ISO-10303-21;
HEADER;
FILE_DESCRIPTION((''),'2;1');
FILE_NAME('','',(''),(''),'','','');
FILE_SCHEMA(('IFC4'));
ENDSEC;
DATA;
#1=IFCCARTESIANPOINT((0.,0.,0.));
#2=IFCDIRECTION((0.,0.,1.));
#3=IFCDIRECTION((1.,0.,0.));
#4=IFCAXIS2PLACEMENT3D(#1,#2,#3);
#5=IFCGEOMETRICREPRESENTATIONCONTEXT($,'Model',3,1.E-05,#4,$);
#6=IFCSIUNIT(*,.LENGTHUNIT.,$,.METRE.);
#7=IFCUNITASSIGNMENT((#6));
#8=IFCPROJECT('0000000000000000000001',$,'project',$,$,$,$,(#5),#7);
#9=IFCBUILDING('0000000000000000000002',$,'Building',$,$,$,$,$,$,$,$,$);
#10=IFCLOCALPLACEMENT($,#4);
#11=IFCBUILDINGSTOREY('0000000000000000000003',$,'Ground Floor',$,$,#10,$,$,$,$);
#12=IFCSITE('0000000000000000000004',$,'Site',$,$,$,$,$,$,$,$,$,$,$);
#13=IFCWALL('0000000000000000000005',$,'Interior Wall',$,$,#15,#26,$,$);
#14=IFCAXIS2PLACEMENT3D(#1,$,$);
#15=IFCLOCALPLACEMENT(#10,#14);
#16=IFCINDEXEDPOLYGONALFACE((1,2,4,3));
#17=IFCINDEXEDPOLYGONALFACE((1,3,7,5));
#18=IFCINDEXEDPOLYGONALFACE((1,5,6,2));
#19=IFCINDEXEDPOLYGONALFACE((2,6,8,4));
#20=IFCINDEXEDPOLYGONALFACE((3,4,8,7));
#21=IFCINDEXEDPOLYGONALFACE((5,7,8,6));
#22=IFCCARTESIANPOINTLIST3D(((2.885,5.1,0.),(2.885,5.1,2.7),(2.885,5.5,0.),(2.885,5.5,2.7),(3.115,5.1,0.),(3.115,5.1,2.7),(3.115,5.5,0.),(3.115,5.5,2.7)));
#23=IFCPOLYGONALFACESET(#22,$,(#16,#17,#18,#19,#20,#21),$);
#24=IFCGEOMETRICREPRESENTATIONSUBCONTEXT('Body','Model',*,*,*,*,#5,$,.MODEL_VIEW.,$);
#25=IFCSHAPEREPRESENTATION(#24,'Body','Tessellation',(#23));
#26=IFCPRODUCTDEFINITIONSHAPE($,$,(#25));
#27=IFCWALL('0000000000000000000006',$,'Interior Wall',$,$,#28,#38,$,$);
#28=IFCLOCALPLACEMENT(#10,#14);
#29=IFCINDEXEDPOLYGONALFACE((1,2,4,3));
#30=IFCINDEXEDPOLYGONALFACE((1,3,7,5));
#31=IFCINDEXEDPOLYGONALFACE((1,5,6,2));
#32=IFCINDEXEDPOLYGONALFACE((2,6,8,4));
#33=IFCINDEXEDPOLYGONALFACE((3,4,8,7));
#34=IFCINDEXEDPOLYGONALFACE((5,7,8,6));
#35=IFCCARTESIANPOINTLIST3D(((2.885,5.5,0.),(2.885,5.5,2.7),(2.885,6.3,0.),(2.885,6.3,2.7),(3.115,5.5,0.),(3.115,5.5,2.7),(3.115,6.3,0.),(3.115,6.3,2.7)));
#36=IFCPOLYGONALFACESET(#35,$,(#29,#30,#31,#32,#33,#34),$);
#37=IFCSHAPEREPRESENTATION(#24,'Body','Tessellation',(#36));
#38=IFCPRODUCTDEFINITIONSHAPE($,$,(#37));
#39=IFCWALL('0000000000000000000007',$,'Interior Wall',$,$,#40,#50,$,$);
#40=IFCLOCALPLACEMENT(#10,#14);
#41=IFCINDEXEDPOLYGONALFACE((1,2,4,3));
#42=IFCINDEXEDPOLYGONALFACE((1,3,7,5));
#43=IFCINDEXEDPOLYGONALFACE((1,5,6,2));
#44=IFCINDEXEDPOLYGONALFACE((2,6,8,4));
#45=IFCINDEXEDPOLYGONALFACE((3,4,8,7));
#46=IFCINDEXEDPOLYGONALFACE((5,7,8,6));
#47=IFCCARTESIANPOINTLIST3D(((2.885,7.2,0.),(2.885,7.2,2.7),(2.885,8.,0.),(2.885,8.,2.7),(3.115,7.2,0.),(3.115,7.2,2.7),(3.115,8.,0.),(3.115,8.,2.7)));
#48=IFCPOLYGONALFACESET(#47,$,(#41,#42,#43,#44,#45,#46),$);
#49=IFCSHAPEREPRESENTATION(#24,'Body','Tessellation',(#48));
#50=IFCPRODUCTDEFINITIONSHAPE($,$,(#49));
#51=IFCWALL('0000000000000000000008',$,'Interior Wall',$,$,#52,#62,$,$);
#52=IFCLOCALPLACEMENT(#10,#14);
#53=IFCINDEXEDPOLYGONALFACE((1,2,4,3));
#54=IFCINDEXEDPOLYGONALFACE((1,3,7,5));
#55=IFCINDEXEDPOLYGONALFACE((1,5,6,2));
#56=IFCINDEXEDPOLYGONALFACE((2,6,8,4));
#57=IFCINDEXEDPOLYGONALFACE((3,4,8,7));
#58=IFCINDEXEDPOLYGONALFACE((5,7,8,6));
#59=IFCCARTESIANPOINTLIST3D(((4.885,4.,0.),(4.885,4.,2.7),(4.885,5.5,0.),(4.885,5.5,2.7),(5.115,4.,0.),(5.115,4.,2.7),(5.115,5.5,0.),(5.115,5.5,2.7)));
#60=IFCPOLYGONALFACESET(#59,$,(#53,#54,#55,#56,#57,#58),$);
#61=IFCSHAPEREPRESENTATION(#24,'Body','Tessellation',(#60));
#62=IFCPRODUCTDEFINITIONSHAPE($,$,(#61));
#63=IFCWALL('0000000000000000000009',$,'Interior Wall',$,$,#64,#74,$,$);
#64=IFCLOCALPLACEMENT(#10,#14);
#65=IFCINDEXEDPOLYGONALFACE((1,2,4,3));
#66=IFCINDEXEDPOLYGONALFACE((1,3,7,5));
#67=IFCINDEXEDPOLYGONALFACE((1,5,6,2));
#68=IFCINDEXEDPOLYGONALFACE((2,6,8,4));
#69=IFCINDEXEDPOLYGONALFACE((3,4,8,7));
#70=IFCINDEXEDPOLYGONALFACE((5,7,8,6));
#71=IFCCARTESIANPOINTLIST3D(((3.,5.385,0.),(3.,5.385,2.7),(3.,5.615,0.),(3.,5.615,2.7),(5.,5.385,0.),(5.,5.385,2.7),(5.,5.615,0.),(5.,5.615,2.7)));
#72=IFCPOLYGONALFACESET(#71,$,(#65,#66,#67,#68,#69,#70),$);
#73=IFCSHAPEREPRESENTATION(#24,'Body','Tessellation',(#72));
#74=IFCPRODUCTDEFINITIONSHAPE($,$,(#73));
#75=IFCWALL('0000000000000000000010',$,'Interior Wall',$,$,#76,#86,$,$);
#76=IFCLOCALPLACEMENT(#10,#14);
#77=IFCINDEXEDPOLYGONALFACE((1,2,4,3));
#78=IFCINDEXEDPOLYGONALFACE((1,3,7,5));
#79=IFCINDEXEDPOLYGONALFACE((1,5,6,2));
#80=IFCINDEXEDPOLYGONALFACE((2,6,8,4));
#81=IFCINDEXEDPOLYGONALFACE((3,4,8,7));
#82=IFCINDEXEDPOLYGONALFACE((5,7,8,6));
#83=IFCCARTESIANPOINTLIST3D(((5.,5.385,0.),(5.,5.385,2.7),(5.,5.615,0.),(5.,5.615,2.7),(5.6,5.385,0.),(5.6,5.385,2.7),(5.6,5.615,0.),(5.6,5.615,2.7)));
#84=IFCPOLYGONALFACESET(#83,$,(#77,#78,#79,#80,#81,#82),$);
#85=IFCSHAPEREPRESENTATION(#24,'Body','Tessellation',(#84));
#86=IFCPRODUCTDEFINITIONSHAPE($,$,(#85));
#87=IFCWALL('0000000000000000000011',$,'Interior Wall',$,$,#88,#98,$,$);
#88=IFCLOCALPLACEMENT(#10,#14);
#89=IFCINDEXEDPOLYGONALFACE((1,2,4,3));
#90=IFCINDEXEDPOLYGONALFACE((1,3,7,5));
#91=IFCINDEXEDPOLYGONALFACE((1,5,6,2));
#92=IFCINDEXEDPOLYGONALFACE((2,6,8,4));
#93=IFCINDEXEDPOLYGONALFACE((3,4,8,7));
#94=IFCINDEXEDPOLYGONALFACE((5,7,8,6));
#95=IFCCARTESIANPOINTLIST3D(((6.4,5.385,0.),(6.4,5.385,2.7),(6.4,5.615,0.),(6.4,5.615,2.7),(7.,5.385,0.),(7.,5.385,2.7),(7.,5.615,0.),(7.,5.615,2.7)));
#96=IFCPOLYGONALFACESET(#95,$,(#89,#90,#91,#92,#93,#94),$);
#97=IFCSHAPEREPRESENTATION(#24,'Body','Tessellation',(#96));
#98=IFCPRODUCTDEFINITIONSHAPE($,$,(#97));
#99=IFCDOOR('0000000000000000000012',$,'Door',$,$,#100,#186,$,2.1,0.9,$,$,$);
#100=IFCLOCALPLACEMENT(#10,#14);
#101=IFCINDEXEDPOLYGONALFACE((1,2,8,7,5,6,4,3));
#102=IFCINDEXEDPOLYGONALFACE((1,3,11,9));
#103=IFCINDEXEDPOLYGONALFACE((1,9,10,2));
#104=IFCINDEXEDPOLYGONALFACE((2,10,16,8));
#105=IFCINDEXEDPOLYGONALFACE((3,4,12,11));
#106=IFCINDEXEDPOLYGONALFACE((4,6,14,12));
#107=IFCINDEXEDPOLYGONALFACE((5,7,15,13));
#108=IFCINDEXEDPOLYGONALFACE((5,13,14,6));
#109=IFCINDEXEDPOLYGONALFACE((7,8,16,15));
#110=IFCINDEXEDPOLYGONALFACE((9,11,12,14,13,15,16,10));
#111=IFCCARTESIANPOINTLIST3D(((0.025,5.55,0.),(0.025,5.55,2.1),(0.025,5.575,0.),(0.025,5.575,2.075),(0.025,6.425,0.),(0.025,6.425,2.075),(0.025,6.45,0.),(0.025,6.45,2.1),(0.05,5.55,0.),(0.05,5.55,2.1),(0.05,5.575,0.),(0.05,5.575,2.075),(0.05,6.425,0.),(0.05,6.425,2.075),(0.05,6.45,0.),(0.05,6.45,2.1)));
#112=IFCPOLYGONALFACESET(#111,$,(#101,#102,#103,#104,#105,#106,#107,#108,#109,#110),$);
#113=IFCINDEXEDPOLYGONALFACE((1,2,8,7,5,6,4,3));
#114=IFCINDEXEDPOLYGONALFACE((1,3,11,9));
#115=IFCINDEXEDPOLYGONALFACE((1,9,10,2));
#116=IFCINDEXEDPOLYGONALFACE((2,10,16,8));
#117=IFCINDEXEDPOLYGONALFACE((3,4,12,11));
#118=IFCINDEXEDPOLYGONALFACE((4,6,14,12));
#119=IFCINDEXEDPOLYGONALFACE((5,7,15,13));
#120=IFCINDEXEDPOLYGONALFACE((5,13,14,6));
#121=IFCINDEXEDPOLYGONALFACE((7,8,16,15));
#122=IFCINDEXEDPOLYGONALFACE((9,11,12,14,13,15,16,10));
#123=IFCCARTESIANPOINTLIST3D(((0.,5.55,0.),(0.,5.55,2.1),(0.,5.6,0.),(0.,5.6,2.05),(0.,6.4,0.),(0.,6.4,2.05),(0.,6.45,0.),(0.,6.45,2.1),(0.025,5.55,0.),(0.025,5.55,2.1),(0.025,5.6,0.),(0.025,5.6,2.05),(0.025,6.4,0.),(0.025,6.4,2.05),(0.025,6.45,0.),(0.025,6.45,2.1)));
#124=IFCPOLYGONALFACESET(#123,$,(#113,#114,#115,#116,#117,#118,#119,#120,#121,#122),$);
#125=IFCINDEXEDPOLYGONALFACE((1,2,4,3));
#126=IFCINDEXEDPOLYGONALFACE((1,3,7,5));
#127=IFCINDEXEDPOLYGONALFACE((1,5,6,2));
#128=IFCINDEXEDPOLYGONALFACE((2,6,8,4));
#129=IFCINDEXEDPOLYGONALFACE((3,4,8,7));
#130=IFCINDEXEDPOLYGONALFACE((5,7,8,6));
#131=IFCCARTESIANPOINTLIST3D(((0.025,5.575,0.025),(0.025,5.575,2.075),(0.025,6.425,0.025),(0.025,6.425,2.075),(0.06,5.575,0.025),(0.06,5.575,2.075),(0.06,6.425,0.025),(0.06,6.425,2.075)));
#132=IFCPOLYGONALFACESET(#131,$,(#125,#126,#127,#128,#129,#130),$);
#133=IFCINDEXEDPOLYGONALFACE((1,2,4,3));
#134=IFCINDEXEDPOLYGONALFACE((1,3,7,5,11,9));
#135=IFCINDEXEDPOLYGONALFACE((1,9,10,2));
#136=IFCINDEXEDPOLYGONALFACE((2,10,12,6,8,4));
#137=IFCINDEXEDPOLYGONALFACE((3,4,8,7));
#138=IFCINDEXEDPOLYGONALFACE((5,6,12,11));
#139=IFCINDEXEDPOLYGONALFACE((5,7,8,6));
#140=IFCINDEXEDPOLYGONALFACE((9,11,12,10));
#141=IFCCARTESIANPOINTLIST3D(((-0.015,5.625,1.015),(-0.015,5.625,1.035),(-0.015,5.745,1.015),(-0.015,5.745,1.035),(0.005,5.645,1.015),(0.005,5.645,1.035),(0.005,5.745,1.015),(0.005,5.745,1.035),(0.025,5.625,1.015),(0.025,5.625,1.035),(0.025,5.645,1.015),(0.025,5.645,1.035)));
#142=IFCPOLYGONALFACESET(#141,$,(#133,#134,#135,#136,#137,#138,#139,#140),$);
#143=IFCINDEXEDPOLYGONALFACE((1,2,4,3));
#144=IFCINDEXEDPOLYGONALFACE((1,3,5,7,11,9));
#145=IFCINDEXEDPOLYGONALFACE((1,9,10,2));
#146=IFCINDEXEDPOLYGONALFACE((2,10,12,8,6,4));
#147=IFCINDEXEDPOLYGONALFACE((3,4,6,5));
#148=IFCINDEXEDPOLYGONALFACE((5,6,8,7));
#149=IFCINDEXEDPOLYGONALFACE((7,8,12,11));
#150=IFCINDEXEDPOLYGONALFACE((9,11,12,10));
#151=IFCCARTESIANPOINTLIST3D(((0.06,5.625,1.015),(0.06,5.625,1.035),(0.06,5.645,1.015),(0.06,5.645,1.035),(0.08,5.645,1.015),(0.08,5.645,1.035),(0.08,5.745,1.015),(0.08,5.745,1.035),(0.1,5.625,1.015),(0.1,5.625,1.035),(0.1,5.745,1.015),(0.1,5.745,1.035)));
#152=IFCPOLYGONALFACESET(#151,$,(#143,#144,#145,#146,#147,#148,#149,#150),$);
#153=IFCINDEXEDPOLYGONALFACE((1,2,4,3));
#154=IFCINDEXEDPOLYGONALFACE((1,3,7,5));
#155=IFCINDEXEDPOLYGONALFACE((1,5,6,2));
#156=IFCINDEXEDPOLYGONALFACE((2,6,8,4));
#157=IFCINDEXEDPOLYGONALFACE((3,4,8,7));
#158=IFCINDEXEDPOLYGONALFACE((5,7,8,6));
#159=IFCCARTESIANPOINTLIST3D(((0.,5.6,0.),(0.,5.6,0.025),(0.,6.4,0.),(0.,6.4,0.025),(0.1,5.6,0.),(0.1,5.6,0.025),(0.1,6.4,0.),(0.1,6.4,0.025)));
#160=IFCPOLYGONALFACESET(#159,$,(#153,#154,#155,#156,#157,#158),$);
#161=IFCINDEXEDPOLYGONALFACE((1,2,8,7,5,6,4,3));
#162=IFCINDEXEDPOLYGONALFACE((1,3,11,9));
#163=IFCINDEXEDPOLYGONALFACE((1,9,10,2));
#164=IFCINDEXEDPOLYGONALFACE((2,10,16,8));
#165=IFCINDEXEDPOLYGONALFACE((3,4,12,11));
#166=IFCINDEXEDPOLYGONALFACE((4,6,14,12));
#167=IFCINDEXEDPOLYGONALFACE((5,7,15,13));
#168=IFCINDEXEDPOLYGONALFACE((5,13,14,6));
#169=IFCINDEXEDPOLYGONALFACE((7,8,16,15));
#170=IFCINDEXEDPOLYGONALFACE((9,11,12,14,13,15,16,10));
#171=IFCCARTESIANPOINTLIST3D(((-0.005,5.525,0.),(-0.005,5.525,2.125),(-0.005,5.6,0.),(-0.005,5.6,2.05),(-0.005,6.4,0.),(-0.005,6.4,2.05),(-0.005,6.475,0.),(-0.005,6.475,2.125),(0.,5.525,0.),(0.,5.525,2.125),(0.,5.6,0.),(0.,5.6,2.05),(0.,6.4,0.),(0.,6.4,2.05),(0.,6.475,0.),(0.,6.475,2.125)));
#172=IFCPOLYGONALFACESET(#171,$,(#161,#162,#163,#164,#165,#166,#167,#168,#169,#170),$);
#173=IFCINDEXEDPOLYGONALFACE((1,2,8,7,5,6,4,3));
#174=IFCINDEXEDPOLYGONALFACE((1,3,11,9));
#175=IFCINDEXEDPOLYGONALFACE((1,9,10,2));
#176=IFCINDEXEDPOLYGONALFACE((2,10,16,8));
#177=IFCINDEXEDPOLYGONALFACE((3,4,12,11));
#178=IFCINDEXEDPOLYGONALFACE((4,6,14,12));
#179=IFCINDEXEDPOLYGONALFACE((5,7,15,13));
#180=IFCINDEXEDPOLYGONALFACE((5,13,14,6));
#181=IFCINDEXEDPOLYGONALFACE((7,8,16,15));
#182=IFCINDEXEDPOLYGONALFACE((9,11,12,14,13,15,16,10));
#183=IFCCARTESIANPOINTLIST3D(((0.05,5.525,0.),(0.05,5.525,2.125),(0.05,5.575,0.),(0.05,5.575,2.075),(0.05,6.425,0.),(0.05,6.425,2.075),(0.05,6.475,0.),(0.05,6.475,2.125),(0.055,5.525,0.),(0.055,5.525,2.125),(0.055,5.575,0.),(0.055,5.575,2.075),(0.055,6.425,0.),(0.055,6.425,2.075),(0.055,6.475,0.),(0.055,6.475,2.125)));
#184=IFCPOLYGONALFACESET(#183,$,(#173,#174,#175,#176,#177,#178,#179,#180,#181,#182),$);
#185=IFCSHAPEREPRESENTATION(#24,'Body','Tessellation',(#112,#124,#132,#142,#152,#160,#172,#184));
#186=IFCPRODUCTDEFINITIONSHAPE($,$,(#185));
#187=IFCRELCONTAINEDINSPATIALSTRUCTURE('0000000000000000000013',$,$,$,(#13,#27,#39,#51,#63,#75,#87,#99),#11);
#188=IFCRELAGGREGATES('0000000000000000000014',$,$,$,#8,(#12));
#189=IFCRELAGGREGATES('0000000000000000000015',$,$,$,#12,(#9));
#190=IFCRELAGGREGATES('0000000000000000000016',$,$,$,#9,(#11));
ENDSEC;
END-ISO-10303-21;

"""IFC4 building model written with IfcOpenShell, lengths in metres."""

from ifc_helpers import new_model, si_unit, frame, origin_with_axes, place, context, subcontext, project, spatial, line, indexed_curve, outline, extrude, element, save


model = new_model("IFC4")

# Units and contexts
model_context = context("Model", 3, precision=1e-05, world=origin_with_axes())
body_context = subcontext(model_context, "Body", "Model", "MODEL_VIEW")
ifc_project = project(units=[si_unit("LENGTHUNIT", "METRE")], contexts=[model_context])

# Site, building, storey
site = spatial("IfcSite", under=ifc_project, Name="Site")
building = spatial("IfcBuilding", under=site, Name="Building")
storey_placement = place(None, origin_with_axes())
storey = spatial("IfcBuildingStorey", under=building, at=storey_placement, Name="Ground Floor")

# Walls
for number, where, z_axis, x_axis, name in (
    (1, (3.0, 5.1, 0.0), (0.0, 0.0, 1.0), (0.0, 1.0, 0.0), "Interior Wall"),
):
    element("IfcWall", number, at=place(storey_placement, frame(where, z_axis=z_axis, x_axis=x_axis)), inside=storey, Name=name, context=body_context, shape_type="SweptSolid", body=[
        extrude(outline(indexed_curve([(0.0, 0.0), (0.0, 0.23), (0.4, 0.23), (0.4, 0.0), (0.0, 0.0)], self_intersect=False)), frame((0.0, -0.115, 0.0), z_axis=(0.0, 0.0, 1.0), x_axis=(1.0, 0.0, 0.0)), (0.0, 0.0, 1.0), 2.7),
    ])
for number, where, z_axis, x_axis, name in (
    (2, (3.0, 5.5, 0.0), (0.0, 0.0, 1.0), (0.0, 1.0, 0.0), "Interior Wall"),
    (3, (3.0, 7.2, 0.0), (0.0, 0.0, 1.0), (0.0, 1.0, 0.0), "Interior Wall"),
):
    element("IfcWall", number, at=place(storey_placement, frame(where, z_axis=z_axis, x_axis=x_axis)), inside=storey, Name=name, context=body_context, shape_type="SweptSolid", body=[
        extrude(outline(indexed_curve([(0.0, 0.0), (0.0, 0.23), (0.8, 0.23), (0.8, 0.0), (0.0, 0.0)], self_intersect=False)), frame((0.0, -0.115, 0.0), z_axis=(0.0, 0.0, 1.0), x_axis=(1.0, 0.0, 0.0)), (0.0, 0.0, 1.0), 2.7),
    ])
wall_1_placement = place(storey_placement, frame((5.0, 4.0, 0.0), z_axis=(0.0, 0.0, 1.0), x_axis=(0.0, 1.0, 0.0)))
element("IfcWall", 4, at=wall_1_placement, inside=storey, Name="Interior Wall", context=body_context, shape_type="SweptSolid", body=[
    extrude(outline(indexed_curve([(0.0, 0.0), (0.0, 0.23), (1.5, 0.23), (1.5, 0.0), (0.0, 0.0)], self_intersect=False)), frame((0.0, -0.115, 0.0), z_axis=(0.0, 0.0, 1.0), x_axis=(1.0, 0.0, 0.0)), (0.0, 0.0, 1.0), 2.7),
])
wall_2_placement = place(storey_placement, frame((5.0, 5.5, 0.0), z_axis=(0.0, 0.0, 1.0), x_axis=(-1.0, 0.0, 0.0)))
element("IfcWall", 5, at=wall_2_placement, inside=storey, Name="Interior Wall", context=body_context, shape_type="SweptSolid", body=[
    extrude(outline(indexed_curve([(0.0, 0.0), (0.0, 0.23), (2.0, 0.23), (2.0, 0.0), (0.0, 0.0)], self_intersect=False)), frame((0.0, -0.115, 0.0), z_axis=(0.0, 0.0, 1.0), x_axis=(1.0, 0.0, 0.0)), (0.0, 0.0, 1.0), 2.7),
])
for number, where, z_axis, x_axis, name in (
    (6, (5.0, 5.5, 0.0), (0.0, 0.0, 1.0), (1.0, 0.0, 0.0), "Interior Wall"),
    (7, (6.4, 5.5, 0.0), (0.0, 0.0, 1.0), (1.0, 0.0, 0.0), "Interior Wall"),
):
    element("IfcWall", number, at=place(storey_placement, frame(where, z_axis=z_axis, x_axis=x_axis)), inside=storey, Name=name, context=body_context, shape_type="SweptSolid", body=[
        extrude(outline(indexed_curve([(0.0, 0.0), (0.0, 0.23), (0.6, 0.23), (0.6, 0.0), (0.0, 0.0)], self_intersect=False)), frame((0.0, -0.115, 0.0), z_axis=(0.0, 0.0, 1.0), x_axis=(1.0, 0.0, 0.0)), (0.0, 0.0, 1.0), 2.7),
    ])

# Door
door_1_placement = place(storey_placement, frame((0.0, 6.45, 0.0), z_axis=(0.0, 0.0, 1.0), x_axis=(0.0, -1.0, 0.0)))
element("IfcDoor", 8, at=door_1_placement, inside=storey, Name="Door", OverallHeight=2.1, OverallWidth=0.9, context=body_context, shape_type="SweptSolid", body=[
    extrude(outline(indexed_curve([(0.0, 0.0), (0.0, 2.1), (0.9, 2.1), (0.9, 0.0), (0.875, 0.0), (0.875, 2.075), (0.025, 2.075), (0.025, 0.0)], segments=[line(1, 2, 3, 4, 5, 6, 7, 8, 1)])), frame((0.0, 0.025, 0.0), z_axis=(0.0, -1.0, 0.0), x_axis=(1.0, 0.0, 0.0)), (0.0, 0.0, -1.0), 0.025),
    extrude(outline(indexed_curve([(0.0, 0.0), (0.0, 2.1), (0.9, 2.1), (0.9, 0.0), (0.85, 0.0), (0.85, 2.05), (0.05, 2.05), (0.05, 0.0)], segments=[line(1, 2, 3, 4, 5, 6, 7, 8, 1)])), frame((0.0, 0.0, 0.0), z_axis=(0.0, -1.0, 0.0), x_axis=(1.0, 0.0, 0.0)), (0.0, 0.0, -1.0), 0.025),
    extrude(outline(indexed_curve([(0.0, 0.0), (0.85, 0.0), (0.85, 0.035), (0.0, 0.035)], segments=[line(1, 2, 3, 4, 1)])), frame((0.025, 0.025, 0.025), z_axis=(0.0, 0.0, 1.0), x_axis=(1.0, 0.0, 0.0)), (0.0, 0.0, 1.0), 2.05),
    extrude(outline(indexed_curve([(0.0, 0.0), (0.0, -0.04), (-0.12, -0.04), (-0.12, -0.02), (-0.02, -0.02), (-0.02, 0.0)], segments=[line(1, 2, 3, 4, 5, 6, 1)])), frame((0.825, 0.025, 1.015), z_axis=(0.0, 0.0, 1.0), x_axis=(1.0, 0.0, 0.0)), (0.0, 0.0, 1.0), 0.02),
    extrude(outline(indexed_curve([(0.0, 0.0), (0.0, 0.04), (-0.12, 0.04), (-0.12, 0.02), (-0.02, 0.02), (-0.02, 0.0)], segments=[line(1, 2, 3, 4, 5, 6, 1)])), frame((0.825, 0.06, 1.015), z_axis=(0.0, 0.0, 1.0), x_axis=(1.0, 0.0, 0.0)), (0.0, 0.0, 1.0), 0.02),
    extrude(outline(indexed_curve([(0.0, 0.0), (0.8, 0.0), (0.8, 0.1), (0.0, 0.1)], segments=[line(1, 2, 3, 4, 1)])), frame((0.05, 0.0, 0.0), z_axis=(0.0, 0.0, 1.0), x_axis=(1.0, 0.0, 0.0)), (0.0, 0.0, 1.0), 0.025),
    extrude(outline(indexed_curve([(0.0, 0.0), (0.0, 2.125), (0.95, 2.125), (0.95, 0.0), (0.875, 0.0), (0.875, 2.05), (0.075, 2.05), (0.075, 0.0)], segments=[line(1, 2, 3, 4, 5, 6, 7, 8, 1)])), frame((-0.025, -0.005, 0.0), z_axis=(0.0, -1.0, 0.0), x_axis=(1.0, 0.0, 0.0)), (0.0, 0.0, -1.0), 0.005),
    extrude(outline(indexed_curve([(0.0, 0.0), (0.0, 2.125), (0.95, 2.125), (0.95, 0.0), (0.9, 0.0), (0.9, 2.075), (0.05, 2.075), (0.05, 0.0)], segments=[line(1, 2, 3, 4, 5, 6, 7, 8, 1)])), frame((-0.025, 0.05, 0.0), z_axis=(0.0, -1.0, 0.0), x_axis=(1.0, 0.0, 0.0)), (0.0, 0.0, -1.0), 0.005),
])

save(model, "model.ifc")
